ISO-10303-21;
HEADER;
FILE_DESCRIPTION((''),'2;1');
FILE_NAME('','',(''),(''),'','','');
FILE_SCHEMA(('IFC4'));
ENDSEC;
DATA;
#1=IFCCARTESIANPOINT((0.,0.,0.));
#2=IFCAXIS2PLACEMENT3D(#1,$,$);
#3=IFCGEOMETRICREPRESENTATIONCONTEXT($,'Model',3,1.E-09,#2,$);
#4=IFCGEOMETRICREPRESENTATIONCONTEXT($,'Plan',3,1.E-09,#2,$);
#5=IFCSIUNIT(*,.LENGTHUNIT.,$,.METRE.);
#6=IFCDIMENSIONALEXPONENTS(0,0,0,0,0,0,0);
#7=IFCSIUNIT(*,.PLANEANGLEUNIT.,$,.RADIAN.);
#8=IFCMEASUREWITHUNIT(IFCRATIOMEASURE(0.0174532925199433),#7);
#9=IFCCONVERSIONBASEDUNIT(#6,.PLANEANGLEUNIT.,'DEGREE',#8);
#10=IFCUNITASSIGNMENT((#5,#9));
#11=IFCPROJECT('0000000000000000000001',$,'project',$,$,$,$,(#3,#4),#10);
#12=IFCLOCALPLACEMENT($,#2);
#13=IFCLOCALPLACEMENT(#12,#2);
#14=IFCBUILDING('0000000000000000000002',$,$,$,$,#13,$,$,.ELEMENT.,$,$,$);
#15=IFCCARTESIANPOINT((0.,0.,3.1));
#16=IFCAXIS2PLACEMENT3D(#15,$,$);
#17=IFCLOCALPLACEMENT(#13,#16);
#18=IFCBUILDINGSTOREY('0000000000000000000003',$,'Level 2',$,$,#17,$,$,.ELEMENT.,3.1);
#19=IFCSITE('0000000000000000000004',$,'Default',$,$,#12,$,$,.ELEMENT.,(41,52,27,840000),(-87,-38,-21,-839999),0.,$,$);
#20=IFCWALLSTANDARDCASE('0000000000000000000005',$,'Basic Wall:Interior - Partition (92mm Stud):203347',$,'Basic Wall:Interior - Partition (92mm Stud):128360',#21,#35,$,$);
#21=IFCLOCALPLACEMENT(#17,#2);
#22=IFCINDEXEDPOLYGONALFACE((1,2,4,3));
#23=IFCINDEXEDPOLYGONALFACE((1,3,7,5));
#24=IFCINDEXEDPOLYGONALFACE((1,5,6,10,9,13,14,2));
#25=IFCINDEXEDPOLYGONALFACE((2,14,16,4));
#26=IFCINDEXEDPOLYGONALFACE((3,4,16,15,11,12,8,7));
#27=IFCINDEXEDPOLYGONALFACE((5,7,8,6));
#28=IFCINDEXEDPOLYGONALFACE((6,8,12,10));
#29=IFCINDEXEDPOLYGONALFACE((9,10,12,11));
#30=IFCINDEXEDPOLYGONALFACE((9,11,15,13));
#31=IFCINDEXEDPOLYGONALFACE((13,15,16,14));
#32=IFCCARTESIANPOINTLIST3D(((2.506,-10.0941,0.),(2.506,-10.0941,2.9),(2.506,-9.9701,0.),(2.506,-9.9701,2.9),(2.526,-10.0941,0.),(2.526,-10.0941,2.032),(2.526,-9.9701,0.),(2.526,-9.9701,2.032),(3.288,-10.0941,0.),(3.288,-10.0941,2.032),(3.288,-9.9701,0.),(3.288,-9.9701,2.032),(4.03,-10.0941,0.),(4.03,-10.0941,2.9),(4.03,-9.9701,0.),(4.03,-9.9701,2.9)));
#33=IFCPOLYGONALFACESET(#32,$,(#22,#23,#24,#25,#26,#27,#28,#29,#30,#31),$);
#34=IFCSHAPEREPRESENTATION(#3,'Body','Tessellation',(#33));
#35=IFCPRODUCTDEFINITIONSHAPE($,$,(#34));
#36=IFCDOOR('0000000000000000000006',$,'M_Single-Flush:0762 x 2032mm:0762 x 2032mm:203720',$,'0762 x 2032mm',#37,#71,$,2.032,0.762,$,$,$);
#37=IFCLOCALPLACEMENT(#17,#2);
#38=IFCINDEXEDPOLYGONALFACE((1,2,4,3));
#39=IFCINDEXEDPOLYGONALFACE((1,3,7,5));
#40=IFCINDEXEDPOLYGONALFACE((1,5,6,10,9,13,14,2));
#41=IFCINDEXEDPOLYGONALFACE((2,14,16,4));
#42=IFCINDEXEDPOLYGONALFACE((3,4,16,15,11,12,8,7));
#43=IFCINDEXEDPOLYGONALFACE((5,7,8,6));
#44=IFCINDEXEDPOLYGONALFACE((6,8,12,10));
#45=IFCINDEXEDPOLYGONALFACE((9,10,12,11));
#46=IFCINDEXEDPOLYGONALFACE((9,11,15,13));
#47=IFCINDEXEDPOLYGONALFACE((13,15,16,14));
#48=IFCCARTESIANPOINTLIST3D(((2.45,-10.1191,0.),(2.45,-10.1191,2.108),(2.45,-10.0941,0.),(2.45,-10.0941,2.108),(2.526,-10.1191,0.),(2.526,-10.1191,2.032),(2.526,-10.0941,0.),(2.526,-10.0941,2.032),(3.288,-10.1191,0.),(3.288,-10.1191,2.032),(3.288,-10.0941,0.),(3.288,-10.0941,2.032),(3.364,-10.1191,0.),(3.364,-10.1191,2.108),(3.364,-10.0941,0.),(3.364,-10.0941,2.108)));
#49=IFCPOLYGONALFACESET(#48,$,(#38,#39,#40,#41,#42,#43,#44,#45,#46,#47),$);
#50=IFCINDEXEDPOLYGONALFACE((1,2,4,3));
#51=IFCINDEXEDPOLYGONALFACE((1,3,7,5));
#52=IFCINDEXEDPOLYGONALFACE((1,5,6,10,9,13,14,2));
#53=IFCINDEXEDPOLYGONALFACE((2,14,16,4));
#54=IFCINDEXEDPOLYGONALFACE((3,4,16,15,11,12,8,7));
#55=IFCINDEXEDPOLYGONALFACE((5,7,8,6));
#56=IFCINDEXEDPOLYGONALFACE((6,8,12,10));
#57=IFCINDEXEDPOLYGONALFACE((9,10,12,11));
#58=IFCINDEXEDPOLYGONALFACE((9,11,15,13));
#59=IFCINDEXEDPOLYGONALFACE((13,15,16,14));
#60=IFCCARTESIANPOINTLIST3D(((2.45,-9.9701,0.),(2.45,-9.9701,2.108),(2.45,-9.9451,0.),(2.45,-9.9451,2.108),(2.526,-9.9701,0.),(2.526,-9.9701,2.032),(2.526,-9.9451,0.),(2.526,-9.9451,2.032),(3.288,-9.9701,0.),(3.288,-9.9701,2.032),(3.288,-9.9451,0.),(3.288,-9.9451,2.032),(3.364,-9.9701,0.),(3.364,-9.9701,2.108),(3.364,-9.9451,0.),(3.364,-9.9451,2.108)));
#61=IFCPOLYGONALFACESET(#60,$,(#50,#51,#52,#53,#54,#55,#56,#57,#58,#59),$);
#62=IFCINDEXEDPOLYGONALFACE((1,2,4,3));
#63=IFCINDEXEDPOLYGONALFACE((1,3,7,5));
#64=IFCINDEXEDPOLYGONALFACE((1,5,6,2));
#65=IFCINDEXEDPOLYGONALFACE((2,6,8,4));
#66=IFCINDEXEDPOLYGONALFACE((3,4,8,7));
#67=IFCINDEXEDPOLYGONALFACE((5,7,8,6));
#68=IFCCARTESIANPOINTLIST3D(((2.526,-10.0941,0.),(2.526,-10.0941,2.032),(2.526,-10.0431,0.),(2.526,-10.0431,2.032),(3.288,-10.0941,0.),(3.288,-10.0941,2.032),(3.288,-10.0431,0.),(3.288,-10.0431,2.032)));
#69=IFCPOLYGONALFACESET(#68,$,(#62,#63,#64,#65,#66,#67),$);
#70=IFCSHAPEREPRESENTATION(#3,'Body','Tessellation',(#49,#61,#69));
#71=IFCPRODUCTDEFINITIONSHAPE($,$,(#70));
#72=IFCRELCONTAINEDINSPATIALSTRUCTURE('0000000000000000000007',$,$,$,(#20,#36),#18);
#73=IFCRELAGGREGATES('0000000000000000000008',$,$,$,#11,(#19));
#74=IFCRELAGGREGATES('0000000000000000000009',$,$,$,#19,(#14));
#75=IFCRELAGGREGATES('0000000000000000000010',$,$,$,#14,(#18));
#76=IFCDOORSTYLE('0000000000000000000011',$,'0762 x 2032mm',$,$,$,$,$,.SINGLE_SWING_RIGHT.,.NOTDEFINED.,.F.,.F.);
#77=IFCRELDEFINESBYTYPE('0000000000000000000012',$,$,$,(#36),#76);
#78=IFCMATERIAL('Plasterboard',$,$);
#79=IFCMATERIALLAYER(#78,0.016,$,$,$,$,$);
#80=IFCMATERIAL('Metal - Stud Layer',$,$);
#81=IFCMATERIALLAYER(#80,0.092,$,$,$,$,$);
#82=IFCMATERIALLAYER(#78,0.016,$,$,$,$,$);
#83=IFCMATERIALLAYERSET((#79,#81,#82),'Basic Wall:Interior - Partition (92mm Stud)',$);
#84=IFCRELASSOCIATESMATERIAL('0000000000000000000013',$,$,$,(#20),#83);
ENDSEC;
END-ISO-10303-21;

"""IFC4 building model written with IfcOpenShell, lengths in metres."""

from ifc_helpers import new_model, entity, si_unit, converted_unit, frame, frame_2d, origin, origin_2d_with_axis, place, context, project, spatial, polyline, rectangle, outline, extrude, source, transform, mapped, material, layer, layer_set, layer_usage, type_object, type_shapes, element, fill, save


model = new_model("IFC4")

# Units and contexts
model_context = context("Model", 3, precision=1e-09, world=origin())
plan_context = context("Plan", 3, precision=1e-09, world=origin())
ifc_project = project(units=[si_unit("LENGTHUNIT", "METRE"), converted_unit("PLANEANGLEUNIT", "DEGREE", entity("IfcRatioMeasure", 0.0174532925199433), si_unit("PLANEANGLEUNIT", "RADIAN"), dimensions=[0, 0, 0, 0, 0, 0, 0])], contexts=[model_context, plan_context])

# Site, building, storey
site_placement = place(None, origin())
site = spatial("IfcSite", under=ifc_project, at=site_placement, Name="Default", CompositionType="ELEMENT", RefLatitude=(41, 52, 27, 840000), RefLongitude=(-87, -38, -21, -839999), RefElevation=0.0)
building_placement = place(site_placement, origin())
building = spatial("IfcBuilding", under=site, at=building_placement, CompositionType="ELEMENT")
storey_placement = place(building_placement, frame((0.0, 0.0, 3.1)))
storey = spatial("IfcBuildingStorey", under=building, at=storey_placement, Name="Level 2", CompositionType="ELEMENT", Elevation=3.1)

# Shared definitions
ifc_material_1 = material(Name="Metal - Stud Layer")
ifc_material_2 = material(Name="Plasterboard")

# Shared definitions
ifc_layer_1 = layer(ifc_material_2, 0.016)
ifc_layer_2 = layer(ifc_material_1, 0.092)
ifc_layer_3 = layer(ifc_material_2, 0.016)
ifc_layer_set_1 = layer_set([ifc_layer_1, ifc_layer_2, ifc_layer_3], Name="Basic Wall:Interior - Partition (92mm Stud)")
door_style = type_object("IfcDoorStyle", Name="0762 x 2032mm", ConstructionType="NOTDEFINED", OperationType="SINGLE_SWING_RIGHT", ParameterTakesPrecedence=False, Sizeable=False)
shared_shape = source(origin(), model_context, "Body", "SweptSolid", [
    extrude(outline(polyline([(-0.457, -1.073), (0.457, -1.073), (0.457, 1.035), (0.381, 1.035), (0.381, -0.997), (-0.381, -0.997), (-0.381, 1.035), (-0.457, 1.035), (-0.457, -1.073)])), frame((0.381, 0.124, 1.035), z_axis=(0.0, 1.0, 0.0), x_axis=(1.0, 0.0, 0.0)), (0.0, 0.0, 1.0), 0.025),
    extrude(outline(polyline([(-1.073, -0.457), (1.035, -0.457), (1.035, -0.381), (-0.997, -0.381), (-0.997, 0.381), (1.035, 0.381), (1.035, 0.457), (-1.073, 0.457), (-1.073, -0.457)])), frame((0.381, -0.025, 1.035), z_axis=(0.0, 1.0, 0.0), x_axis=(0.0, 0.0, -1.0)), (0.0, 0.0, 1.0), 0.025),
    extrude(rectangle(XDim=0.051, YDim=0.762, at=origin_2d_with_axis()), frame((0.381, 0.0985, 0.0), z_axis=(0.0, 0.0, 1.0), x_axis=(0.0, 1.0, 0.0)), (0.0, 0.0, 1.0), 2.032),
])
type_shapes(door_style, [shared_shape])

# Wall, opening, door
ifc_layer_usage_1 = layer_usage(ifc_layer_set_1, "AXIS2", "NEGATIVE", 0.062)
wall_1_placement = place(storey_placement, frame((4.03, -10.0321, 0.0), z_axis=(0.0, 0.0, 1.0), x_axis=(-1.0, 0.0, 0.0)))
wall_1 = element("IfcWallStandardCase", 1, at=wall_1_placement, inside=storey, material=ifc_layer_usage_1, Name="Basic Wall:Interior - Partition (92mm Stud):203347", ObjectType="Basic Wall:Interior - Partition (92mm Stud):128360", context=model_context, shape_type="SweptSolid", body=[
    extrude(rectangle(XDim=1.524, YDim=0.124, at=frame_2d((0.762, 0.0), x_axis=(-1.0, 0.0))), origin(), (0.0, 0.0, 1.0), 2.9),
])
opening_1_placement = place(wall_1_placement, frame((0.742, -0.062, 0.0)))
opening_1 = element("IfcOpeningElement", 2, at=opening_1_placement, cuts=wall_1, ObjectType="Opening", context=model_context, shape_type="SweptSolid", body=[
    extrude(rectangle(XDim=0.762, YDim=2.032, at=frame_2d((1.016, 0.381), x_axis=(0.0, 1.0))), frame((0.0, 0.0, 0.0), z_axis=(0.0, 1.0, 0.0), x_axis=(0.0, 0.0, 1.0)), (0.0, 0.0, 1.0), 0.124),
])
door_1_placement = place(opening_1_placement, origin())
door_1 = element("IfcDoor", 3, at=door_1_placement, inside=storey, type_object=door_style, Name="M_Single-Flush:0762 x 2032mm:0762 x 2032mm:203720", ObjectType="0762 x 2032mm", OverallHeight=2.032, OverallWidth=0.762, context=model_context, shape_type="MappedRepresentation", body=[
    mapped(shared_shape, transform((0.0, 0.0, 0.0), scale=1.0)),
])
fill(opening_1, door_1)

save(model, "model.ifc")
